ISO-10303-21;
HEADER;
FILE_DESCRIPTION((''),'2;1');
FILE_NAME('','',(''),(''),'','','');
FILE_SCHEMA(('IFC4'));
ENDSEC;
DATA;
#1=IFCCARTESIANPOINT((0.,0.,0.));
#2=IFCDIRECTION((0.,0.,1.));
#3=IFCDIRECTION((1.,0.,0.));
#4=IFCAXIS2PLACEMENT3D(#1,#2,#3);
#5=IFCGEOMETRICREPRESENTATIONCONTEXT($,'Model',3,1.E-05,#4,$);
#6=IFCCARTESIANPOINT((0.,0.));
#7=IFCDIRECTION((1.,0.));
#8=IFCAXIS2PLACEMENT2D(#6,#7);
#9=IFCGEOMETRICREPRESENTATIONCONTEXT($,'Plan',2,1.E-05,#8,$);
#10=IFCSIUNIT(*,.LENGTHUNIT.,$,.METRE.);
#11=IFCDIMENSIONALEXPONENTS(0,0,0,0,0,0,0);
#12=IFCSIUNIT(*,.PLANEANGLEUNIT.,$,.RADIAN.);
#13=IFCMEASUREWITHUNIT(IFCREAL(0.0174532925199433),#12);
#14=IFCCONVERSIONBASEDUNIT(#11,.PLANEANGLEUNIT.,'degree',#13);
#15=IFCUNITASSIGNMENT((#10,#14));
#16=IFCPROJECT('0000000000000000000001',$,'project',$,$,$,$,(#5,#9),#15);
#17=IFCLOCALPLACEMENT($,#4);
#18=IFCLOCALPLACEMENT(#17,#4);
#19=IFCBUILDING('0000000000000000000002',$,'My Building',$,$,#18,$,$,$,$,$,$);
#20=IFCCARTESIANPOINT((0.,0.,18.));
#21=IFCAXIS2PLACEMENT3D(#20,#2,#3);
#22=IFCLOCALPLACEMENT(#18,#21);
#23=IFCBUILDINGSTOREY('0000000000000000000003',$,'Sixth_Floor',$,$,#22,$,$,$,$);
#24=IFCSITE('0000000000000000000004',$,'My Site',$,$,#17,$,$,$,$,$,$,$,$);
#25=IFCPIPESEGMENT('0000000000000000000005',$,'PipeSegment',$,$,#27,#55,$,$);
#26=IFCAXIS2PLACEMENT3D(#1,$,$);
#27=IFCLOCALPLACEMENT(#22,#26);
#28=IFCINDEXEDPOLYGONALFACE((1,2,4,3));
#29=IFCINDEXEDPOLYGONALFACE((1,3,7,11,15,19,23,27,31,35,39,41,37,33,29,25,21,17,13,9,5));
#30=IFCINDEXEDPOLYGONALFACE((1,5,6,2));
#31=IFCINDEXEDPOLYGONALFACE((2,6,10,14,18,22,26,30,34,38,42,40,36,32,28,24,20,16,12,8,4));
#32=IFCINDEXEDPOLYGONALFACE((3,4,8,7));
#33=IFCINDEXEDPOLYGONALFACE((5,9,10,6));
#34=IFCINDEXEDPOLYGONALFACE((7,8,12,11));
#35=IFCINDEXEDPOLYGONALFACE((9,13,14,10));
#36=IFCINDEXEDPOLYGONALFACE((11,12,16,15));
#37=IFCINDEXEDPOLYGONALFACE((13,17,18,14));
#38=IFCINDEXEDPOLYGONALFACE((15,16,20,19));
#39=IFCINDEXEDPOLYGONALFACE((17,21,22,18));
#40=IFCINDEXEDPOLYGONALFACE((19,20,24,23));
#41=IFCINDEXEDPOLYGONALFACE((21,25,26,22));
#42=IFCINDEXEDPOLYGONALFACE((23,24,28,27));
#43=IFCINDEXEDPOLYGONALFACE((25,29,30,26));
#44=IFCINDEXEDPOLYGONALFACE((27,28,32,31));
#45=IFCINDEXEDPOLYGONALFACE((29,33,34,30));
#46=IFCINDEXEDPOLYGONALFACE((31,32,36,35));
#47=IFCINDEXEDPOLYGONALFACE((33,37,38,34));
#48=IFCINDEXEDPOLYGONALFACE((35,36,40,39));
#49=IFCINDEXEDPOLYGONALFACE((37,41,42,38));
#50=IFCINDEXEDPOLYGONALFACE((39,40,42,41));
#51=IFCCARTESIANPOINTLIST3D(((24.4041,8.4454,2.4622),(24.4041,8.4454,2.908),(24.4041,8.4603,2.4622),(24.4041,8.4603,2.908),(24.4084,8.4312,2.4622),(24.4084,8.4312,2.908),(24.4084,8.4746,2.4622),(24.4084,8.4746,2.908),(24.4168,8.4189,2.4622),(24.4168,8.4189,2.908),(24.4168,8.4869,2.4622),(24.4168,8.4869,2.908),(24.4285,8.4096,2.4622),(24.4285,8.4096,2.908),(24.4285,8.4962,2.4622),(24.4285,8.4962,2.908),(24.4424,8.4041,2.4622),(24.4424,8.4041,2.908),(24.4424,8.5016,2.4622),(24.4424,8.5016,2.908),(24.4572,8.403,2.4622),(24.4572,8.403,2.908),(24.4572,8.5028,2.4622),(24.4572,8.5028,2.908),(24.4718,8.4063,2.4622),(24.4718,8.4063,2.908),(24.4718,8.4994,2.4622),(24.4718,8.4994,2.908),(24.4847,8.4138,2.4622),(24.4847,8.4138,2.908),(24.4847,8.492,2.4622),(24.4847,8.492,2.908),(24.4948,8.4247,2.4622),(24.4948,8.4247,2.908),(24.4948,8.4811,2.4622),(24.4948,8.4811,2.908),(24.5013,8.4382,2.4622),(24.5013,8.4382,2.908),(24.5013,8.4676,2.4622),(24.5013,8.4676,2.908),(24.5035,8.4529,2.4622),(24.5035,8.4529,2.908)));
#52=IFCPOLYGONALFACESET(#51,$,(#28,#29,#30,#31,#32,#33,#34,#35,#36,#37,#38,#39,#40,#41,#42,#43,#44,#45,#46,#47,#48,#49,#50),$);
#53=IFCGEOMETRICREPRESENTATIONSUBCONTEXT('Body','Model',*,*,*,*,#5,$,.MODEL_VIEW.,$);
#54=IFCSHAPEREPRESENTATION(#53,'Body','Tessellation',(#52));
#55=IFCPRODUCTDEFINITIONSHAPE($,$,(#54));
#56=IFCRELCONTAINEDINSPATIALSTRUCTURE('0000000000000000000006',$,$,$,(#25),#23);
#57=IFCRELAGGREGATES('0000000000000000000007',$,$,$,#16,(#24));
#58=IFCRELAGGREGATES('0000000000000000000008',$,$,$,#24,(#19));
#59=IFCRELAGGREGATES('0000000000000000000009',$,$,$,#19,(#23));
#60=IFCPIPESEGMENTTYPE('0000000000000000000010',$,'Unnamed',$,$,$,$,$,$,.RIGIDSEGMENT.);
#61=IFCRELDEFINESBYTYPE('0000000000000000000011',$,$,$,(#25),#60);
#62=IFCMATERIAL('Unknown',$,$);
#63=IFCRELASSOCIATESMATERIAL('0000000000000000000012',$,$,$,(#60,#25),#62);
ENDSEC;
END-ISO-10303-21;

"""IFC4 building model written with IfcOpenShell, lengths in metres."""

from ifc_helpers import new_model, entity, si_unit, converted_unit, frame, origin_with_axes, origin_2d_with_axis, place, context, subcontext, project, spatial, circle, extrude, material, material_profile, profile_set, profile_usage, type_object, element, save


model = new_model("IFC4")

# Units and contexts
model_context = context("Model", 3, precision=1e-05, world=origin_with_axes())
plan_context = context("Plan", 2, precision=1e-05, world=origin_2d_with_axis())
body_context = subcontext(model_context, "Body", "Model", "MODEL_VIEW")
ifc_project = project(units=[si_unit("LENGTHUNIT", "METRE"), converted_unit("PLANEANGLEUNIT", "degree", entity("IfcReal", 0.0174532925199433), si_unit("PLANEANGLEUNIT", "RADIAN"), dimensions=[0, 0, 0, 0, 0, 0, 0])], contexts=[model_context, plan_context])

# Site, building, storey
site_placement = place(None, origin_with_axes())
site = spatial("IfcSite", under=ifc_project, at=site_placement, Name="My Site")
building_placement = place(site_placement, origin_with_axes())
building = spatial("IfcBuilding", under=site, at=building_placement, Name="My Building")
storey_placement = place(building_placement, frame((0.0, 0.0, 18.0), z_axis=(0.0, 0.0, 1.0), x_axis=(1.0, 0.0, 0.0)))
storey = spatial("IfcBuildingStorey", under=building, at=storey_placement, Name="Sixth_Floor")

# Shared definitions
ifc_material = material(Name="Unknown")

# Pipe segment
ifc_material_profile_1 = material_profile(ifc_material, circle(Radius=0.05))
ifc_profile_set_1 = profile_set([ifc_material_profile_1])
pipe_segment_type = type_object("IfcPipeSegmentType", Name="Unnamed", PredefinedType="RIGIDSEGMENT", material=ifc_profile_set_1)
ifc_profile_usage_1 = profile_usage(ifc_profile_set_1, cardinal=5)
pipe_segment_1_placement = place(storey_placement, frame((24.4535, 8.4529, 2.908), z_axis=(0.0, 0.0, -1.0), x_axis=(1.0, 0.0, 0.0)))
element("IfcPipeSegment", 1, at=pipe_segment_1_placement, inside=storey, type_object=pipe_segment_type, material=ifc_profile_usage_1, Name="PipeSegment", context=body_context, shape_type="SweptSolid", body=[
    extrude(circle(Radius=0.05), origin_with_axes(), (0.0, 0.0, 1.0), 0.4458),
])

save(model, "model.ifc")
